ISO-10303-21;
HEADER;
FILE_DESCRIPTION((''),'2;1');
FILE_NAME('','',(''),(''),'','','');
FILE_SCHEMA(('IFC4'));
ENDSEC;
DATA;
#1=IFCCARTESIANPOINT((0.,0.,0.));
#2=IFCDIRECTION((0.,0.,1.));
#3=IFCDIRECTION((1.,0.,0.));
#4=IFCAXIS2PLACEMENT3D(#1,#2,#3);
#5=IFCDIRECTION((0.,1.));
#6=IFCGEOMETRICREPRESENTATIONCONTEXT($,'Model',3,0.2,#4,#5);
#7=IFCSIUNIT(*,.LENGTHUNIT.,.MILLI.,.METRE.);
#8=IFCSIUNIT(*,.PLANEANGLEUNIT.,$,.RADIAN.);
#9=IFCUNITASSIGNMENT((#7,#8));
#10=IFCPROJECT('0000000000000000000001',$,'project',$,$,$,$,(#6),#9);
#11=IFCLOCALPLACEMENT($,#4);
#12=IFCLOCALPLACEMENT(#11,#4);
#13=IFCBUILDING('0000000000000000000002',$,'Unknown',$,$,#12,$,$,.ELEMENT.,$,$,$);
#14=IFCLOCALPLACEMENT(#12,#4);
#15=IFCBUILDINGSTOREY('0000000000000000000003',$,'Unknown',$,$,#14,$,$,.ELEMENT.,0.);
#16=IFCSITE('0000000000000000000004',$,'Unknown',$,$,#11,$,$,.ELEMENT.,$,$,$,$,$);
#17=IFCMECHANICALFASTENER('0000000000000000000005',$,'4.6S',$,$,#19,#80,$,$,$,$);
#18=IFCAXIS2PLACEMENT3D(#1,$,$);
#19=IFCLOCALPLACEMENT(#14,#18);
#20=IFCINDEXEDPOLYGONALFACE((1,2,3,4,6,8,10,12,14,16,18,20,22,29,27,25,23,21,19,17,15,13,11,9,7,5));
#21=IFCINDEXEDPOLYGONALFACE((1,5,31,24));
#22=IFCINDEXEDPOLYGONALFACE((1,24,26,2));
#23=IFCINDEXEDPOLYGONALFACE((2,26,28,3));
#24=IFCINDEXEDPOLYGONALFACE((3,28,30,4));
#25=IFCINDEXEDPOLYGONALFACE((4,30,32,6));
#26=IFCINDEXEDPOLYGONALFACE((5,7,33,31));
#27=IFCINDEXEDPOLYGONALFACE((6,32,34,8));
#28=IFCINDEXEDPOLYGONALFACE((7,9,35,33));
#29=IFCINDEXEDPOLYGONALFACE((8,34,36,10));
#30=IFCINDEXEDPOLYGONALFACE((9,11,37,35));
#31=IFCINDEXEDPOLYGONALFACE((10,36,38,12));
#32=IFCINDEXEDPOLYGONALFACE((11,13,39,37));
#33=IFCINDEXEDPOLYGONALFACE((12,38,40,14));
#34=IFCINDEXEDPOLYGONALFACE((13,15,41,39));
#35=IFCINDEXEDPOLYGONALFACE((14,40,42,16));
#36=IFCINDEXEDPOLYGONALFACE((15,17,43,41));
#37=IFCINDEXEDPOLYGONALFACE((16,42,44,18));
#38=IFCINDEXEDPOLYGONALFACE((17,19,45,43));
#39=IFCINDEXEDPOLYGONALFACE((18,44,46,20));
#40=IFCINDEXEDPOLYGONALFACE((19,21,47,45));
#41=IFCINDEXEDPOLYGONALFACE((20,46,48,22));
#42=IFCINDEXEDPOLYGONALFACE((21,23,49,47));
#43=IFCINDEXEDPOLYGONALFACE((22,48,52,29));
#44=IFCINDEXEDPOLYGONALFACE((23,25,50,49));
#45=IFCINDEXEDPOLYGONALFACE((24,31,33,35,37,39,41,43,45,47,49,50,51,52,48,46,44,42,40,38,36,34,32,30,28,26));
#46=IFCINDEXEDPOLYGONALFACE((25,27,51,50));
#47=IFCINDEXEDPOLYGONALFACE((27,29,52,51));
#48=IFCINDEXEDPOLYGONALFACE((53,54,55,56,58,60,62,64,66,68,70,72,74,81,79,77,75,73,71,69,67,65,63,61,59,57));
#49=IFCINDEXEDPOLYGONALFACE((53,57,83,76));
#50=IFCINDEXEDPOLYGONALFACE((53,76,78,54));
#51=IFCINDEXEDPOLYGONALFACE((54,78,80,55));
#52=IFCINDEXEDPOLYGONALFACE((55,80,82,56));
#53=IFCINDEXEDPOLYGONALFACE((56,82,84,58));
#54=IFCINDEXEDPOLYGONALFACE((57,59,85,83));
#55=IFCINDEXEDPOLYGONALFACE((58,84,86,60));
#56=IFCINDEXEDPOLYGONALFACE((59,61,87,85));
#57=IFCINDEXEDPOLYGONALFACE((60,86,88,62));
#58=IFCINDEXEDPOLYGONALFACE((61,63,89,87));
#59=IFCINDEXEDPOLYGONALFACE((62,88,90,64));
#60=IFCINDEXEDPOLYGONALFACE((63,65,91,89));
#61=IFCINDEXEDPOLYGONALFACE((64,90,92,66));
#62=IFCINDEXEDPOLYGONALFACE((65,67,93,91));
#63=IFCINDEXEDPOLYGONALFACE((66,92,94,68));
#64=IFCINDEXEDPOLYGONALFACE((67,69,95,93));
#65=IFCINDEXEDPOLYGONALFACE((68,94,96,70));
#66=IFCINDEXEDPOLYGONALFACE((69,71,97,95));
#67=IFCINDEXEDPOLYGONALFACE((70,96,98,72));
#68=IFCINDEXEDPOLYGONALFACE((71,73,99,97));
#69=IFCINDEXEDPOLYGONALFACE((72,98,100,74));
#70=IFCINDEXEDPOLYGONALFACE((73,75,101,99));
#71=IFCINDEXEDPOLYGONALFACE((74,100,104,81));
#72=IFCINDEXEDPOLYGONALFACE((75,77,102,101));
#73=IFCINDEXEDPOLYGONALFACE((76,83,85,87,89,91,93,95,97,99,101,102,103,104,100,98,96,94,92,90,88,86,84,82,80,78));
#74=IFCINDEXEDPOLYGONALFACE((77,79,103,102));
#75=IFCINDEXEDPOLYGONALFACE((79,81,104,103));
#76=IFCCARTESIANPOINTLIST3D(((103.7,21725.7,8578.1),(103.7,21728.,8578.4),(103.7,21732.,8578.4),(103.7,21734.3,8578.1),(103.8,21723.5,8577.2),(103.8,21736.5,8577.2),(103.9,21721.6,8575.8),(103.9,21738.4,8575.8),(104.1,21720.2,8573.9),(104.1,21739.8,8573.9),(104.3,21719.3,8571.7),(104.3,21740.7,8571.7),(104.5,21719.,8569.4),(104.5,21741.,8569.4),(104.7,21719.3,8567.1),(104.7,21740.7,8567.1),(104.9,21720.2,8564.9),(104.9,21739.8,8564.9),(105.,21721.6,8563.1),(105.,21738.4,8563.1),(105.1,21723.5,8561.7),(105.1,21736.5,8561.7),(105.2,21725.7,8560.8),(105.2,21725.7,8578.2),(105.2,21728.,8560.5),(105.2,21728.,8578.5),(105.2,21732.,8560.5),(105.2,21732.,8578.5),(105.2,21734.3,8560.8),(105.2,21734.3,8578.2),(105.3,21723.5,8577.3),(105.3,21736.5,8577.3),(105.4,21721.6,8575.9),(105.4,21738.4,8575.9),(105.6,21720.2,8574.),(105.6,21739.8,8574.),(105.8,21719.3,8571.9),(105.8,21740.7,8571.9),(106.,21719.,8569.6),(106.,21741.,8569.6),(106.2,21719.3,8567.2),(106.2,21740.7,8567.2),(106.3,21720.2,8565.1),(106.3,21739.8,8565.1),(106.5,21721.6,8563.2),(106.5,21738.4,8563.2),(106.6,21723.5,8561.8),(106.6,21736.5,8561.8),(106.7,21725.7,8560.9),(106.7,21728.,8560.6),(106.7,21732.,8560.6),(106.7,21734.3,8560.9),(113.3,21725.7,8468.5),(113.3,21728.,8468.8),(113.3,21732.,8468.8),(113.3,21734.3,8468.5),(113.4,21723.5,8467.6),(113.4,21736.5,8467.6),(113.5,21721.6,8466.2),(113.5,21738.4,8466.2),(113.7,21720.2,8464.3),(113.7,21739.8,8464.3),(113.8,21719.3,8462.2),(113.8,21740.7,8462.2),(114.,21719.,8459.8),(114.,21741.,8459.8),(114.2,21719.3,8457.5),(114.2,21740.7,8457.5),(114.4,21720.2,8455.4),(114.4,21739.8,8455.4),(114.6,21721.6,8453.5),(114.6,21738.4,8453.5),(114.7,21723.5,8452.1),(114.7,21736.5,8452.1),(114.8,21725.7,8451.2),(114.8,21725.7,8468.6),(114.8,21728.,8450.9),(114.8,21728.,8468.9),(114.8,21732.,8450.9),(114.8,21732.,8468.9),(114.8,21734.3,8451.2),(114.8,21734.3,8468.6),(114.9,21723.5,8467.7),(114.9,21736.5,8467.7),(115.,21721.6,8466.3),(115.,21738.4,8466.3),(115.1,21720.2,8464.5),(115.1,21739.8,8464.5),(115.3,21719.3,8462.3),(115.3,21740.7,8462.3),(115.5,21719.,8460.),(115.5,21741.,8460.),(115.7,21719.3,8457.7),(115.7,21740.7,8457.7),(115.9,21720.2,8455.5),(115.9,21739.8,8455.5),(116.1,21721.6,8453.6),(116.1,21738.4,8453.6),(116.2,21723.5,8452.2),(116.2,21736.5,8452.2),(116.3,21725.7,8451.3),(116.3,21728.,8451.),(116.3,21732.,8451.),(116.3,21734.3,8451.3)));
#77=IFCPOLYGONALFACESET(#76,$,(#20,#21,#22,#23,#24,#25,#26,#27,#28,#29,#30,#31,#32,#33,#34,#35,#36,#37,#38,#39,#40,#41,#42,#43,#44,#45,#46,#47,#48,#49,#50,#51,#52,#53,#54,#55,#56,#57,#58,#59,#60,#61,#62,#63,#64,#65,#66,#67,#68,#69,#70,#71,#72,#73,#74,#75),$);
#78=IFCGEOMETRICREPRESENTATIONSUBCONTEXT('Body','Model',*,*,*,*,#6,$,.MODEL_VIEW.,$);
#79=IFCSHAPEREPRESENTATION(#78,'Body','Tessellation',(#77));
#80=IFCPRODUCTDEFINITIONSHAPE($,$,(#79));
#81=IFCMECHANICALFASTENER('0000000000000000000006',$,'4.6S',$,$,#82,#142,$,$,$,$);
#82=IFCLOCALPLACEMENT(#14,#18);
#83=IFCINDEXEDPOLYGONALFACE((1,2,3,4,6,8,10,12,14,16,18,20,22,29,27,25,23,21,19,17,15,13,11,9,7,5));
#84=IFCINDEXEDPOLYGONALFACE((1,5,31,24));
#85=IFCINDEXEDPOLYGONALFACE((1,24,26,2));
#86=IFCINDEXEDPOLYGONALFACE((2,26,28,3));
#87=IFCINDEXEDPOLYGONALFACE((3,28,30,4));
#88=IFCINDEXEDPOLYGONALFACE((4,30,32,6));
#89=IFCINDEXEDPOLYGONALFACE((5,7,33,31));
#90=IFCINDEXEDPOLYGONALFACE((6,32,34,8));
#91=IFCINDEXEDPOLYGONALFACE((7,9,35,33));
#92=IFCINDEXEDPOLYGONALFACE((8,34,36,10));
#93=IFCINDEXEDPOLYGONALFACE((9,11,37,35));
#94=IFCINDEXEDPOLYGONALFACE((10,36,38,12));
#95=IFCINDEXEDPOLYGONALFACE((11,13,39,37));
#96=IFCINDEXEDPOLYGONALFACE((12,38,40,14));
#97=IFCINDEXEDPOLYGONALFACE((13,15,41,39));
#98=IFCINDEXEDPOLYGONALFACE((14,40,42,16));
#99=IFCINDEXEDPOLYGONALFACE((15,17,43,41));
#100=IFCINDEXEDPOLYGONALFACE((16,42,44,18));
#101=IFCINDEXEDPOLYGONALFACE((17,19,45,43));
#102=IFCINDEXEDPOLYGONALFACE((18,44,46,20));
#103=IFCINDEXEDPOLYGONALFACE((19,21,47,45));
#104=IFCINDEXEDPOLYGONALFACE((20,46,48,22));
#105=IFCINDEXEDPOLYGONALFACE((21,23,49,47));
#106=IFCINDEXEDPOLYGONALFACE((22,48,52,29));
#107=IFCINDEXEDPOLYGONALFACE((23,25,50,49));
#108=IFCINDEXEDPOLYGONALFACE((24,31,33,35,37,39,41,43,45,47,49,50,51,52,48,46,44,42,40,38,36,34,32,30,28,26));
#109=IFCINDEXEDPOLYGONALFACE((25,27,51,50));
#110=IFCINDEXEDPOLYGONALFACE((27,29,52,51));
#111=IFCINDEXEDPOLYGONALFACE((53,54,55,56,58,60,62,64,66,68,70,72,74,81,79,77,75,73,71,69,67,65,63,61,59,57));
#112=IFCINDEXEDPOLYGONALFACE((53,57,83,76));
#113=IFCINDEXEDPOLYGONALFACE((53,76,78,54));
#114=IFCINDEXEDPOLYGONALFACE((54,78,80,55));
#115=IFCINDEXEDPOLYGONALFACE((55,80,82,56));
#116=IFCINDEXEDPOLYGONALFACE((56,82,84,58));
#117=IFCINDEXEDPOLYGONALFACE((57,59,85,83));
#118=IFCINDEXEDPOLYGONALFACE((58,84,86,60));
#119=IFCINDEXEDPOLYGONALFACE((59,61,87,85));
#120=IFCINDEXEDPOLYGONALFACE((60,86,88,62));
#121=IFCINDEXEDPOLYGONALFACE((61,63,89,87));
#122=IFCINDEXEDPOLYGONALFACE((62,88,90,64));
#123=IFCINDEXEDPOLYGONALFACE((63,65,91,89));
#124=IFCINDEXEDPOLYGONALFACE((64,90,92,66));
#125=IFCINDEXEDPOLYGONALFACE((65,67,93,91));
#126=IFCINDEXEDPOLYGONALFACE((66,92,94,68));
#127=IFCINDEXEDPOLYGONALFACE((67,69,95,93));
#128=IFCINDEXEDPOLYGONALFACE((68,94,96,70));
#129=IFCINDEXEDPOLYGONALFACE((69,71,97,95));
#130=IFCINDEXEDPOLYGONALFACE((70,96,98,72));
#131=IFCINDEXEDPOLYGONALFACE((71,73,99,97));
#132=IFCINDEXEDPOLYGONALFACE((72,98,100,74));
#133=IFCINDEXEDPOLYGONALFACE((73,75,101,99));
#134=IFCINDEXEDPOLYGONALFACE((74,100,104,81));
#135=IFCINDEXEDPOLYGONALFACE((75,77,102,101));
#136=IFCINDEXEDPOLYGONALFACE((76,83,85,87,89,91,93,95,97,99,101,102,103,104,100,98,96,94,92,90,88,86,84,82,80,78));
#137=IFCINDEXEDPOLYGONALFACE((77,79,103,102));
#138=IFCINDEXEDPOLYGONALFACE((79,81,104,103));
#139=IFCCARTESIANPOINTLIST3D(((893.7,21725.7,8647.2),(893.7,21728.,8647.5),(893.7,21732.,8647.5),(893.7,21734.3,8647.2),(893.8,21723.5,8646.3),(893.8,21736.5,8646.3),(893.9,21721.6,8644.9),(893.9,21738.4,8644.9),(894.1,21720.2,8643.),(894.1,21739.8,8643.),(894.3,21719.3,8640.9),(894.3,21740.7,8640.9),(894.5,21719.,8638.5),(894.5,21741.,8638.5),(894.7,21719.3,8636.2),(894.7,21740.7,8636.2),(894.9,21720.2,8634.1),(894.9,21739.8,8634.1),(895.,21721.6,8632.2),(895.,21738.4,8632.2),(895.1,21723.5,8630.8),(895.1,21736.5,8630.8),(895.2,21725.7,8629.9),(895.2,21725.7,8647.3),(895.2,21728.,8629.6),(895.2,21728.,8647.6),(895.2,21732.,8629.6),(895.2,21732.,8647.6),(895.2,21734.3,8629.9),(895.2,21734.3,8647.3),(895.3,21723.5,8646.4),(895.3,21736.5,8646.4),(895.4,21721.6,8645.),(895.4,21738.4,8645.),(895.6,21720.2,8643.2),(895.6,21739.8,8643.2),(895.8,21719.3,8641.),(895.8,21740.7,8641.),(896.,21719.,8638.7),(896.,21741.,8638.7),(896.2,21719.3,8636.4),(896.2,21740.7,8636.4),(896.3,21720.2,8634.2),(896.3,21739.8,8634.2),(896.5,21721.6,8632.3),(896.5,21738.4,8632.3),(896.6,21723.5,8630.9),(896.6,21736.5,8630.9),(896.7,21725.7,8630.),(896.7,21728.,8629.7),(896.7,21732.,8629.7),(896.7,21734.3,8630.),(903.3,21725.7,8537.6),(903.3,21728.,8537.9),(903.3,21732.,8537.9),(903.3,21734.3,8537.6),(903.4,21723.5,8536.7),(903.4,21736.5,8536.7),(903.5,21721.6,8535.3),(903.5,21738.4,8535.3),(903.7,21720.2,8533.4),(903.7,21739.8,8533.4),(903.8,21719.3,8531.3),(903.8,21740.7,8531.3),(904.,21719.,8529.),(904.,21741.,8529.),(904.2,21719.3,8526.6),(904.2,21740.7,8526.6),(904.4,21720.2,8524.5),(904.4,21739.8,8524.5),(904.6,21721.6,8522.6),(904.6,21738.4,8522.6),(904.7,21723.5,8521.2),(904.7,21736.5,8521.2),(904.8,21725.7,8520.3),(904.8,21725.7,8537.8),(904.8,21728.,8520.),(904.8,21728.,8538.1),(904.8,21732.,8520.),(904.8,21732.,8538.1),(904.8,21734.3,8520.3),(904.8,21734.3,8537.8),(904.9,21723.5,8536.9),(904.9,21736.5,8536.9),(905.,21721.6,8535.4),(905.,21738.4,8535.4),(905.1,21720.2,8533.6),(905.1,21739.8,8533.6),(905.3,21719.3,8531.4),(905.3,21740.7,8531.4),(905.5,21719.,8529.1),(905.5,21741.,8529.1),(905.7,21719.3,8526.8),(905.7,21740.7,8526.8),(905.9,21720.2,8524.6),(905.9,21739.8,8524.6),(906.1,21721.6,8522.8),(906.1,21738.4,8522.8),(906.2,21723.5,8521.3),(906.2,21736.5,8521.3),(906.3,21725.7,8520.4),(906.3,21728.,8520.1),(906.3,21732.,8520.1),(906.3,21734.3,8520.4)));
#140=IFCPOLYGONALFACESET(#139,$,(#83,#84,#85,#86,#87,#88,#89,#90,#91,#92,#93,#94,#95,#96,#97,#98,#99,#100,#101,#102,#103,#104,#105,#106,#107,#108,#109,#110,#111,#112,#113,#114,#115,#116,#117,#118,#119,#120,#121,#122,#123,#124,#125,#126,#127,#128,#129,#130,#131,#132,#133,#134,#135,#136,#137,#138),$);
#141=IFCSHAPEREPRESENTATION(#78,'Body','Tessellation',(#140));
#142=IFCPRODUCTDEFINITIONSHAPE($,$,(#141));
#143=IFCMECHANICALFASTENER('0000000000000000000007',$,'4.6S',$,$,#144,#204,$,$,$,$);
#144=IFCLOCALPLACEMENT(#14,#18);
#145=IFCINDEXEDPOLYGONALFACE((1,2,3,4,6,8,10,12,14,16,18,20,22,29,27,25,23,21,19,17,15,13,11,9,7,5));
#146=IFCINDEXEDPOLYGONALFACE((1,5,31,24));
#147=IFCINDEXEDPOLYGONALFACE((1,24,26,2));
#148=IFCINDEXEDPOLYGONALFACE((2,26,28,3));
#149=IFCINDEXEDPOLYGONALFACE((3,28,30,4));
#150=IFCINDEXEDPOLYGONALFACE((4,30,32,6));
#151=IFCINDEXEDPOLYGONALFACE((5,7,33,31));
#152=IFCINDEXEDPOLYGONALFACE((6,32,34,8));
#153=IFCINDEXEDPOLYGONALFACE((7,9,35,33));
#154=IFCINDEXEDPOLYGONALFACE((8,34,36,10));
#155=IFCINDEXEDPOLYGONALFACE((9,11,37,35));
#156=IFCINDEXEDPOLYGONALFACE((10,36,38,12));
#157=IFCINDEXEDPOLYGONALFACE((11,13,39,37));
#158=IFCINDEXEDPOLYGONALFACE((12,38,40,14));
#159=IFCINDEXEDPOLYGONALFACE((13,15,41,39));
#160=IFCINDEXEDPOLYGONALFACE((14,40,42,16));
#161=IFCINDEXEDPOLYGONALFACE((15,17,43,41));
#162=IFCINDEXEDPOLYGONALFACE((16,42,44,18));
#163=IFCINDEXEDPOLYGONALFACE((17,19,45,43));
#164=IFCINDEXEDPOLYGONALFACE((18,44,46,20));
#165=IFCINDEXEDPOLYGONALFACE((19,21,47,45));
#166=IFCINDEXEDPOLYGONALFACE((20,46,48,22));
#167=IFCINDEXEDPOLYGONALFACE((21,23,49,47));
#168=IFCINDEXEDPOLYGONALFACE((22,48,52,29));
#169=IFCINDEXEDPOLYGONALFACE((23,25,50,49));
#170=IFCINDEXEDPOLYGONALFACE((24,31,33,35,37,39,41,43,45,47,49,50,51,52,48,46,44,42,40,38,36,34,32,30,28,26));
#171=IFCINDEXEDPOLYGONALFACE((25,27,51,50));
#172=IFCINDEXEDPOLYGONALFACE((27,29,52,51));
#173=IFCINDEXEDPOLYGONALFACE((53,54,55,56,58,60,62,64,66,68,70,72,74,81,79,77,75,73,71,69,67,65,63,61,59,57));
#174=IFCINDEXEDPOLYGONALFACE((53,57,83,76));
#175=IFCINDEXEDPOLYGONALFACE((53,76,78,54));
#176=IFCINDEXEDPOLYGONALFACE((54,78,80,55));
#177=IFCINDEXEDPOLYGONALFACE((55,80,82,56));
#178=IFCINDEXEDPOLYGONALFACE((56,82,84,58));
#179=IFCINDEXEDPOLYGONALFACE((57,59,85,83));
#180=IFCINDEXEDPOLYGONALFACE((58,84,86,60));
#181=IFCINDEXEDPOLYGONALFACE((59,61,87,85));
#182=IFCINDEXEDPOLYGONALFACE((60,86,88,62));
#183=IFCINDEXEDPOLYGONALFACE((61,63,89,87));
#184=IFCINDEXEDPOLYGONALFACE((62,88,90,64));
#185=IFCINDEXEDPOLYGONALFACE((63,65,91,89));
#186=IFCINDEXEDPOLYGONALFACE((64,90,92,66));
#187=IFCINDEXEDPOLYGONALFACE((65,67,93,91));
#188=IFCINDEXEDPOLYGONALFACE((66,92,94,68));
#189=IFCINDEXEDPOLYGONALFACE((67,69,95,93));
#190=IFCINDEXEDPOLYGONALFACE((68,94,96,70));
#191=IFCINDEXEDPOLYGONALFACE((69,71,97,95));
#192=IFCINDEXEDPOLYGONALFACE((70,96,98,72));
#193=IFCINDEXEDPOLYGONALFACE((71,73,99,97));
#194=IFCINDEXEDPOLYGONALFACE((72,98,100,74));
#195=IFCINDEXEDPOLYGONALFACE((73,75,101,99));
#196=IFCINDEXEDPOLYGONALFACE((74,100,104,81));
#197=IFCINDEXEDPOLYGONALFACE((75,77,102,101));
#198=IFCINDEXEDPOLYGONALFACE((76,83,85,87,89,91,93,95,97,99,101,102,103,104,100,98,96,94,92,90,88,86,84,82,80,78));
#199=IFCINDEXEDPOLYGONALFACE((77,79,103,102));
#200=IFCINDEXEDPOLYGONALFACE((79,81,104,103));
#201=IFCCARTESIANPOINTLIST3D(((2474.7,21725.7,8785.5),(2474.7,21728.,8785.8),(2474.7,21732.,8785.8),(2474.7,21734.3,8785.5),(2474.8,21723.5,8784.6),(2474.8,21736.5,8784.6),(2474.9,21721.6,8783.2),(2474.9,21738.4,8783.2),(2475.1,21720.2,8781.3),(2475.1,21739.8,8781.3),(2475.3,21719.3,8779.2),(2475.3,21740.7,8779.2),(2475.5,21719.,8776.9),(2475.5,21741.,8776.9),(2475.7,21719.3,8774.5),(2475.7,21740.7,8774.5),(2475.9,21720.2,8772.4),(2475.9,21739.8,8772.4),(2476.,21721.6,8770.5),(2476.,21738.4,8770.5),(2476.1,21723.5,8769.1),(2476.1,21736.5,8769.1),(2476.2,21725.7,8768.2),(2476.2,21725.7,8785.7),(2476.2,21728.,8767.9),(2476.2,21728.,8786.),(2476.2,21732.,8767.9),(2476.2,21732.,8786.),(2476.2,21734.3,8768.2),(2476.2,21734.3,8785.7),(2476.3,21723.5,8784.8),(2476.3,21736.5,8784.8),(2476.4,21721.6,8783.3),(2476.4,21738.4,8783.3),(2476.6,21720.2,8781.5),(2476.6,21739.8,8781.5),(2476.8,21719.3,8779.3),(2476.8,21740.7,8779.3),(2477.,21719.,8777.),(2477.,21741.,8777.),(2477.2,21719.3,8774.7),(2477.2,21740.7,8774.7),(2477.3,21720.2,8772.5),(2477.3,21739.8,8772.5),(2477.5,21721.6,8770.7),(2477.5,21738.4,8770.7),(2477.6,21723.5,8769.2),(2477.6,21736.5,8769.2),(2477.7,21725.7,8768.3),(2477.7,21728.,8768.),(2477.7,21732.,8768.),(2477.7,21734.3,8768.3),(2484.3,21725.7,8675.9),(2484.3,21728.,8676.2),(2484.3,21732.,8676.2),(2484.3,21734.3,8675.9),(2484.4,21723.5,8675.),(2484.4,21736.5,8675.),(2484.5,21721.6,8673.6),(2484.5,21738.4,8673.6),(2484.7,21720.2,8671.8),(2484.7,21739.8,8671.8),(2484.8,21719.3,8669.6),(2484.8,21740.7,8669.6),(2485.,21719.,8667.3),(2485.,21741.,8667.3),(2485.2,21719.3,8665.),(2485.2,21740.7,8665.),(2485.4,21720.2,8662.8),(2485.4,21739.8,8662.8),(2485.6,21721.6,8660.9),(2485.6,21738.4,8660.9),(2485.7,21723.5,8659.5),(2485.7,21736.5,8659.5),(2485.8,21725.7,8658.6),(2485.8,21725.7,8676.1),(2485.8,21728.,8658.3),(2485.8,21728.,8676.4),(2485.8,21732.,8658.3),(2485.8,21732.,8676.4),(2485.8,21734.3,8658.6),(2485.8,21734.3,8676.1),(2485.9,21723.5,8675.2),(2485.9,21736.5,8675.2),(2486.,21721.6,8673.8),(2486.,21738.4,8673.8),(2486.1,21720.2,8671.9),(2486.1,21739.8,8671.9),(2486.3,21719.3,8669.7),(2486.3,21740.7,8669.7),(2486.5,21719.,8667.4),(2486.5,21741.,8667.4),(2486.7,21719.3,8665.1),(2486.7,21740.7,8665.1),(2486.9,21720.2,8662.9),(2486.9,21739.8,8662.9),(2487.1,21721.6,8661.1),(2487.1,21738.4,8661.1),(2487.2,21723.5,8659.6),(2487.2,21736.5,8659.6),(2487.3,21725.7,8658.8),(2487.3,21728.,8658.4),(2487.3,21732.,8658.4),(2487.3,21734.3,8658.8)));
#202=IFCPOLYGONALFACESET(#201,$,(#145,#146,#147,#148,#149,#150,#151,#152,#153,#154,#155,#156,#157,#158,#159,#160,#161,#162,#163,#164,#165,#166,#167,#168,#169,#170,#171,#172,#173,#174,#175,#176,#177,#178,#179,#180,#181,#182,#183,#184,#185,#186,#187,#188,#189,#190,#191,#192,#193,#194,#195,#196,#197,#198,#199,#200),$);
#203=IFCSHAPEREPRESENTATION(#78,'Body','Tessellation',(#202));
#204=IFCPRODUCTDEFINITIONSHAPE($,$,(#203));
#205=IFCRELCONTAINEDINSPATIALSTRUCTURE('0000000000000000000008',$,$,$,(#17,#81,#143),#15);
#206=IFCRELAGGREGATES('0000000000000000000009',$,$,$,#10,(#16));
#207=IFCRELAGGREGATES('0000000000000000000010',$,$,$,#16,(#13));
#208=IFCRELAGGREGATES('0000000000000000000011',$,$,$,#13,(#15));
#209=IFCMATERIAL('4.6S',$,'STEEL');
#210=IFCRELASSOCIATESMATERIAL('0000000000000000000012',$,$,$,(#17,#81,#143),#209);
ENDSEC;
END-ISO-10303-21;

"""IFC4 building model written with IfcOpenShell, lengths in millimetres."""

from ifc_helpers import new_model, si_unit, direction, frame, origin_with_axes, place, context, subcontext, project, spatial, line, arc, indexed_curve, outline, extrude, source, transform, mapped, material, element, save


model = new_model("IFC4")

# Units and contexts
model_context = context("Model", 3, precision=0.2, world=origin_with_axes(), true_north=direction((0.0, 1.0)))
body_context = subcontext(model_context, "Body", "Model", "MODEL_VIEW")
ifc_project = project(units=[si_unit("LENGTHUNIT", "METRE", prefix="MILLI"), si_unit("PLANEANGLEUNIT", "RADIAN")], contexts=[model_context])

# Site, building, storey
site_placement = place(None, origin_with_axes())
site = spatial("IfcSite", under=ifc_project, at=site_placement, Name="Unknown", CompositionType="ELEMENT")
building_placement = place(site_placement, origin_with_axes())
building = spatial("IfcBuilding", under=site, at=building_placement, Name="Unknown", CompositionType="ELEMENT")
storey_placement = place(building_placement, origin_with_axes())
storey = spatial("IfcBuildingStorey", under=building, at=storey_placement, Name="Unknown", CompositionType="ELEMENT", Elevation=0.0)

# Mechanical fasteners
ifc_material_1 = material(Name="4.6S", Category="STEEL")
shared_shape_1 = source(origin_with_axes(), body_context, "Body", "SweptSolid", [
    extrude(outline(indexed_curve([(-2.0, 9.0), (2.0, 9.0), (2.0, 9.0), (8.4, 6.4), (11.0, 0.0), (8.4, -6.4), (2.0, -9.0), (-2.0, -9.0), (-2.8, -9.0), (-11.0, 0.0), (-8.4, 6.4)], segments=[line(1, 2, 3), arc(3, 4, 5), arc(5, 6, 7), line(7, 8), arc(8, 9, 10), arc(10, 11, 1)])), frame((0.0, 0.0, 0.8), z_axis=(0.0, 0.0, -1.0), x_axis=(0.0, 1.0, 0.0)), (0.0, 0.0, 1.0), 1.5),
])
for number, where, z_axis, x_axis, name in (
    (1, (114.8, 21730.0, 8459.9), (-0.996194, 0.0, -0.087159), (-0.087159, 0.0, 0.996194), "4.6S"),
    (2, (904.8, 21730.0, 8529.0), (-0.996194, 0.0, -0.087159), (-0.087159, 0.0, 0.996194), "4.6S"),
    (3, (2485.8, 21730.0, 8667.3), (-0.996194, 0.0, -0.087159), (-0.087159, 0.0, 0.996194), "4.6S"),
):
    element("IfcMechanicalFastener", number, at=place(storey_placement, frame(where, z_axis=z_axis, x_axis=x_axis)), inside=storey, material=ifc_material_1, Name=name, context=body_context, shape_type="MappedRepresentation", body=[
        mapped(shared_shape_1, transform((0.0, 0.0, 0.0))),
        mapped(shared_shape_1, transform((110.0, 0.0, 0.0))),
    ])

save(model, "model.ifc")
